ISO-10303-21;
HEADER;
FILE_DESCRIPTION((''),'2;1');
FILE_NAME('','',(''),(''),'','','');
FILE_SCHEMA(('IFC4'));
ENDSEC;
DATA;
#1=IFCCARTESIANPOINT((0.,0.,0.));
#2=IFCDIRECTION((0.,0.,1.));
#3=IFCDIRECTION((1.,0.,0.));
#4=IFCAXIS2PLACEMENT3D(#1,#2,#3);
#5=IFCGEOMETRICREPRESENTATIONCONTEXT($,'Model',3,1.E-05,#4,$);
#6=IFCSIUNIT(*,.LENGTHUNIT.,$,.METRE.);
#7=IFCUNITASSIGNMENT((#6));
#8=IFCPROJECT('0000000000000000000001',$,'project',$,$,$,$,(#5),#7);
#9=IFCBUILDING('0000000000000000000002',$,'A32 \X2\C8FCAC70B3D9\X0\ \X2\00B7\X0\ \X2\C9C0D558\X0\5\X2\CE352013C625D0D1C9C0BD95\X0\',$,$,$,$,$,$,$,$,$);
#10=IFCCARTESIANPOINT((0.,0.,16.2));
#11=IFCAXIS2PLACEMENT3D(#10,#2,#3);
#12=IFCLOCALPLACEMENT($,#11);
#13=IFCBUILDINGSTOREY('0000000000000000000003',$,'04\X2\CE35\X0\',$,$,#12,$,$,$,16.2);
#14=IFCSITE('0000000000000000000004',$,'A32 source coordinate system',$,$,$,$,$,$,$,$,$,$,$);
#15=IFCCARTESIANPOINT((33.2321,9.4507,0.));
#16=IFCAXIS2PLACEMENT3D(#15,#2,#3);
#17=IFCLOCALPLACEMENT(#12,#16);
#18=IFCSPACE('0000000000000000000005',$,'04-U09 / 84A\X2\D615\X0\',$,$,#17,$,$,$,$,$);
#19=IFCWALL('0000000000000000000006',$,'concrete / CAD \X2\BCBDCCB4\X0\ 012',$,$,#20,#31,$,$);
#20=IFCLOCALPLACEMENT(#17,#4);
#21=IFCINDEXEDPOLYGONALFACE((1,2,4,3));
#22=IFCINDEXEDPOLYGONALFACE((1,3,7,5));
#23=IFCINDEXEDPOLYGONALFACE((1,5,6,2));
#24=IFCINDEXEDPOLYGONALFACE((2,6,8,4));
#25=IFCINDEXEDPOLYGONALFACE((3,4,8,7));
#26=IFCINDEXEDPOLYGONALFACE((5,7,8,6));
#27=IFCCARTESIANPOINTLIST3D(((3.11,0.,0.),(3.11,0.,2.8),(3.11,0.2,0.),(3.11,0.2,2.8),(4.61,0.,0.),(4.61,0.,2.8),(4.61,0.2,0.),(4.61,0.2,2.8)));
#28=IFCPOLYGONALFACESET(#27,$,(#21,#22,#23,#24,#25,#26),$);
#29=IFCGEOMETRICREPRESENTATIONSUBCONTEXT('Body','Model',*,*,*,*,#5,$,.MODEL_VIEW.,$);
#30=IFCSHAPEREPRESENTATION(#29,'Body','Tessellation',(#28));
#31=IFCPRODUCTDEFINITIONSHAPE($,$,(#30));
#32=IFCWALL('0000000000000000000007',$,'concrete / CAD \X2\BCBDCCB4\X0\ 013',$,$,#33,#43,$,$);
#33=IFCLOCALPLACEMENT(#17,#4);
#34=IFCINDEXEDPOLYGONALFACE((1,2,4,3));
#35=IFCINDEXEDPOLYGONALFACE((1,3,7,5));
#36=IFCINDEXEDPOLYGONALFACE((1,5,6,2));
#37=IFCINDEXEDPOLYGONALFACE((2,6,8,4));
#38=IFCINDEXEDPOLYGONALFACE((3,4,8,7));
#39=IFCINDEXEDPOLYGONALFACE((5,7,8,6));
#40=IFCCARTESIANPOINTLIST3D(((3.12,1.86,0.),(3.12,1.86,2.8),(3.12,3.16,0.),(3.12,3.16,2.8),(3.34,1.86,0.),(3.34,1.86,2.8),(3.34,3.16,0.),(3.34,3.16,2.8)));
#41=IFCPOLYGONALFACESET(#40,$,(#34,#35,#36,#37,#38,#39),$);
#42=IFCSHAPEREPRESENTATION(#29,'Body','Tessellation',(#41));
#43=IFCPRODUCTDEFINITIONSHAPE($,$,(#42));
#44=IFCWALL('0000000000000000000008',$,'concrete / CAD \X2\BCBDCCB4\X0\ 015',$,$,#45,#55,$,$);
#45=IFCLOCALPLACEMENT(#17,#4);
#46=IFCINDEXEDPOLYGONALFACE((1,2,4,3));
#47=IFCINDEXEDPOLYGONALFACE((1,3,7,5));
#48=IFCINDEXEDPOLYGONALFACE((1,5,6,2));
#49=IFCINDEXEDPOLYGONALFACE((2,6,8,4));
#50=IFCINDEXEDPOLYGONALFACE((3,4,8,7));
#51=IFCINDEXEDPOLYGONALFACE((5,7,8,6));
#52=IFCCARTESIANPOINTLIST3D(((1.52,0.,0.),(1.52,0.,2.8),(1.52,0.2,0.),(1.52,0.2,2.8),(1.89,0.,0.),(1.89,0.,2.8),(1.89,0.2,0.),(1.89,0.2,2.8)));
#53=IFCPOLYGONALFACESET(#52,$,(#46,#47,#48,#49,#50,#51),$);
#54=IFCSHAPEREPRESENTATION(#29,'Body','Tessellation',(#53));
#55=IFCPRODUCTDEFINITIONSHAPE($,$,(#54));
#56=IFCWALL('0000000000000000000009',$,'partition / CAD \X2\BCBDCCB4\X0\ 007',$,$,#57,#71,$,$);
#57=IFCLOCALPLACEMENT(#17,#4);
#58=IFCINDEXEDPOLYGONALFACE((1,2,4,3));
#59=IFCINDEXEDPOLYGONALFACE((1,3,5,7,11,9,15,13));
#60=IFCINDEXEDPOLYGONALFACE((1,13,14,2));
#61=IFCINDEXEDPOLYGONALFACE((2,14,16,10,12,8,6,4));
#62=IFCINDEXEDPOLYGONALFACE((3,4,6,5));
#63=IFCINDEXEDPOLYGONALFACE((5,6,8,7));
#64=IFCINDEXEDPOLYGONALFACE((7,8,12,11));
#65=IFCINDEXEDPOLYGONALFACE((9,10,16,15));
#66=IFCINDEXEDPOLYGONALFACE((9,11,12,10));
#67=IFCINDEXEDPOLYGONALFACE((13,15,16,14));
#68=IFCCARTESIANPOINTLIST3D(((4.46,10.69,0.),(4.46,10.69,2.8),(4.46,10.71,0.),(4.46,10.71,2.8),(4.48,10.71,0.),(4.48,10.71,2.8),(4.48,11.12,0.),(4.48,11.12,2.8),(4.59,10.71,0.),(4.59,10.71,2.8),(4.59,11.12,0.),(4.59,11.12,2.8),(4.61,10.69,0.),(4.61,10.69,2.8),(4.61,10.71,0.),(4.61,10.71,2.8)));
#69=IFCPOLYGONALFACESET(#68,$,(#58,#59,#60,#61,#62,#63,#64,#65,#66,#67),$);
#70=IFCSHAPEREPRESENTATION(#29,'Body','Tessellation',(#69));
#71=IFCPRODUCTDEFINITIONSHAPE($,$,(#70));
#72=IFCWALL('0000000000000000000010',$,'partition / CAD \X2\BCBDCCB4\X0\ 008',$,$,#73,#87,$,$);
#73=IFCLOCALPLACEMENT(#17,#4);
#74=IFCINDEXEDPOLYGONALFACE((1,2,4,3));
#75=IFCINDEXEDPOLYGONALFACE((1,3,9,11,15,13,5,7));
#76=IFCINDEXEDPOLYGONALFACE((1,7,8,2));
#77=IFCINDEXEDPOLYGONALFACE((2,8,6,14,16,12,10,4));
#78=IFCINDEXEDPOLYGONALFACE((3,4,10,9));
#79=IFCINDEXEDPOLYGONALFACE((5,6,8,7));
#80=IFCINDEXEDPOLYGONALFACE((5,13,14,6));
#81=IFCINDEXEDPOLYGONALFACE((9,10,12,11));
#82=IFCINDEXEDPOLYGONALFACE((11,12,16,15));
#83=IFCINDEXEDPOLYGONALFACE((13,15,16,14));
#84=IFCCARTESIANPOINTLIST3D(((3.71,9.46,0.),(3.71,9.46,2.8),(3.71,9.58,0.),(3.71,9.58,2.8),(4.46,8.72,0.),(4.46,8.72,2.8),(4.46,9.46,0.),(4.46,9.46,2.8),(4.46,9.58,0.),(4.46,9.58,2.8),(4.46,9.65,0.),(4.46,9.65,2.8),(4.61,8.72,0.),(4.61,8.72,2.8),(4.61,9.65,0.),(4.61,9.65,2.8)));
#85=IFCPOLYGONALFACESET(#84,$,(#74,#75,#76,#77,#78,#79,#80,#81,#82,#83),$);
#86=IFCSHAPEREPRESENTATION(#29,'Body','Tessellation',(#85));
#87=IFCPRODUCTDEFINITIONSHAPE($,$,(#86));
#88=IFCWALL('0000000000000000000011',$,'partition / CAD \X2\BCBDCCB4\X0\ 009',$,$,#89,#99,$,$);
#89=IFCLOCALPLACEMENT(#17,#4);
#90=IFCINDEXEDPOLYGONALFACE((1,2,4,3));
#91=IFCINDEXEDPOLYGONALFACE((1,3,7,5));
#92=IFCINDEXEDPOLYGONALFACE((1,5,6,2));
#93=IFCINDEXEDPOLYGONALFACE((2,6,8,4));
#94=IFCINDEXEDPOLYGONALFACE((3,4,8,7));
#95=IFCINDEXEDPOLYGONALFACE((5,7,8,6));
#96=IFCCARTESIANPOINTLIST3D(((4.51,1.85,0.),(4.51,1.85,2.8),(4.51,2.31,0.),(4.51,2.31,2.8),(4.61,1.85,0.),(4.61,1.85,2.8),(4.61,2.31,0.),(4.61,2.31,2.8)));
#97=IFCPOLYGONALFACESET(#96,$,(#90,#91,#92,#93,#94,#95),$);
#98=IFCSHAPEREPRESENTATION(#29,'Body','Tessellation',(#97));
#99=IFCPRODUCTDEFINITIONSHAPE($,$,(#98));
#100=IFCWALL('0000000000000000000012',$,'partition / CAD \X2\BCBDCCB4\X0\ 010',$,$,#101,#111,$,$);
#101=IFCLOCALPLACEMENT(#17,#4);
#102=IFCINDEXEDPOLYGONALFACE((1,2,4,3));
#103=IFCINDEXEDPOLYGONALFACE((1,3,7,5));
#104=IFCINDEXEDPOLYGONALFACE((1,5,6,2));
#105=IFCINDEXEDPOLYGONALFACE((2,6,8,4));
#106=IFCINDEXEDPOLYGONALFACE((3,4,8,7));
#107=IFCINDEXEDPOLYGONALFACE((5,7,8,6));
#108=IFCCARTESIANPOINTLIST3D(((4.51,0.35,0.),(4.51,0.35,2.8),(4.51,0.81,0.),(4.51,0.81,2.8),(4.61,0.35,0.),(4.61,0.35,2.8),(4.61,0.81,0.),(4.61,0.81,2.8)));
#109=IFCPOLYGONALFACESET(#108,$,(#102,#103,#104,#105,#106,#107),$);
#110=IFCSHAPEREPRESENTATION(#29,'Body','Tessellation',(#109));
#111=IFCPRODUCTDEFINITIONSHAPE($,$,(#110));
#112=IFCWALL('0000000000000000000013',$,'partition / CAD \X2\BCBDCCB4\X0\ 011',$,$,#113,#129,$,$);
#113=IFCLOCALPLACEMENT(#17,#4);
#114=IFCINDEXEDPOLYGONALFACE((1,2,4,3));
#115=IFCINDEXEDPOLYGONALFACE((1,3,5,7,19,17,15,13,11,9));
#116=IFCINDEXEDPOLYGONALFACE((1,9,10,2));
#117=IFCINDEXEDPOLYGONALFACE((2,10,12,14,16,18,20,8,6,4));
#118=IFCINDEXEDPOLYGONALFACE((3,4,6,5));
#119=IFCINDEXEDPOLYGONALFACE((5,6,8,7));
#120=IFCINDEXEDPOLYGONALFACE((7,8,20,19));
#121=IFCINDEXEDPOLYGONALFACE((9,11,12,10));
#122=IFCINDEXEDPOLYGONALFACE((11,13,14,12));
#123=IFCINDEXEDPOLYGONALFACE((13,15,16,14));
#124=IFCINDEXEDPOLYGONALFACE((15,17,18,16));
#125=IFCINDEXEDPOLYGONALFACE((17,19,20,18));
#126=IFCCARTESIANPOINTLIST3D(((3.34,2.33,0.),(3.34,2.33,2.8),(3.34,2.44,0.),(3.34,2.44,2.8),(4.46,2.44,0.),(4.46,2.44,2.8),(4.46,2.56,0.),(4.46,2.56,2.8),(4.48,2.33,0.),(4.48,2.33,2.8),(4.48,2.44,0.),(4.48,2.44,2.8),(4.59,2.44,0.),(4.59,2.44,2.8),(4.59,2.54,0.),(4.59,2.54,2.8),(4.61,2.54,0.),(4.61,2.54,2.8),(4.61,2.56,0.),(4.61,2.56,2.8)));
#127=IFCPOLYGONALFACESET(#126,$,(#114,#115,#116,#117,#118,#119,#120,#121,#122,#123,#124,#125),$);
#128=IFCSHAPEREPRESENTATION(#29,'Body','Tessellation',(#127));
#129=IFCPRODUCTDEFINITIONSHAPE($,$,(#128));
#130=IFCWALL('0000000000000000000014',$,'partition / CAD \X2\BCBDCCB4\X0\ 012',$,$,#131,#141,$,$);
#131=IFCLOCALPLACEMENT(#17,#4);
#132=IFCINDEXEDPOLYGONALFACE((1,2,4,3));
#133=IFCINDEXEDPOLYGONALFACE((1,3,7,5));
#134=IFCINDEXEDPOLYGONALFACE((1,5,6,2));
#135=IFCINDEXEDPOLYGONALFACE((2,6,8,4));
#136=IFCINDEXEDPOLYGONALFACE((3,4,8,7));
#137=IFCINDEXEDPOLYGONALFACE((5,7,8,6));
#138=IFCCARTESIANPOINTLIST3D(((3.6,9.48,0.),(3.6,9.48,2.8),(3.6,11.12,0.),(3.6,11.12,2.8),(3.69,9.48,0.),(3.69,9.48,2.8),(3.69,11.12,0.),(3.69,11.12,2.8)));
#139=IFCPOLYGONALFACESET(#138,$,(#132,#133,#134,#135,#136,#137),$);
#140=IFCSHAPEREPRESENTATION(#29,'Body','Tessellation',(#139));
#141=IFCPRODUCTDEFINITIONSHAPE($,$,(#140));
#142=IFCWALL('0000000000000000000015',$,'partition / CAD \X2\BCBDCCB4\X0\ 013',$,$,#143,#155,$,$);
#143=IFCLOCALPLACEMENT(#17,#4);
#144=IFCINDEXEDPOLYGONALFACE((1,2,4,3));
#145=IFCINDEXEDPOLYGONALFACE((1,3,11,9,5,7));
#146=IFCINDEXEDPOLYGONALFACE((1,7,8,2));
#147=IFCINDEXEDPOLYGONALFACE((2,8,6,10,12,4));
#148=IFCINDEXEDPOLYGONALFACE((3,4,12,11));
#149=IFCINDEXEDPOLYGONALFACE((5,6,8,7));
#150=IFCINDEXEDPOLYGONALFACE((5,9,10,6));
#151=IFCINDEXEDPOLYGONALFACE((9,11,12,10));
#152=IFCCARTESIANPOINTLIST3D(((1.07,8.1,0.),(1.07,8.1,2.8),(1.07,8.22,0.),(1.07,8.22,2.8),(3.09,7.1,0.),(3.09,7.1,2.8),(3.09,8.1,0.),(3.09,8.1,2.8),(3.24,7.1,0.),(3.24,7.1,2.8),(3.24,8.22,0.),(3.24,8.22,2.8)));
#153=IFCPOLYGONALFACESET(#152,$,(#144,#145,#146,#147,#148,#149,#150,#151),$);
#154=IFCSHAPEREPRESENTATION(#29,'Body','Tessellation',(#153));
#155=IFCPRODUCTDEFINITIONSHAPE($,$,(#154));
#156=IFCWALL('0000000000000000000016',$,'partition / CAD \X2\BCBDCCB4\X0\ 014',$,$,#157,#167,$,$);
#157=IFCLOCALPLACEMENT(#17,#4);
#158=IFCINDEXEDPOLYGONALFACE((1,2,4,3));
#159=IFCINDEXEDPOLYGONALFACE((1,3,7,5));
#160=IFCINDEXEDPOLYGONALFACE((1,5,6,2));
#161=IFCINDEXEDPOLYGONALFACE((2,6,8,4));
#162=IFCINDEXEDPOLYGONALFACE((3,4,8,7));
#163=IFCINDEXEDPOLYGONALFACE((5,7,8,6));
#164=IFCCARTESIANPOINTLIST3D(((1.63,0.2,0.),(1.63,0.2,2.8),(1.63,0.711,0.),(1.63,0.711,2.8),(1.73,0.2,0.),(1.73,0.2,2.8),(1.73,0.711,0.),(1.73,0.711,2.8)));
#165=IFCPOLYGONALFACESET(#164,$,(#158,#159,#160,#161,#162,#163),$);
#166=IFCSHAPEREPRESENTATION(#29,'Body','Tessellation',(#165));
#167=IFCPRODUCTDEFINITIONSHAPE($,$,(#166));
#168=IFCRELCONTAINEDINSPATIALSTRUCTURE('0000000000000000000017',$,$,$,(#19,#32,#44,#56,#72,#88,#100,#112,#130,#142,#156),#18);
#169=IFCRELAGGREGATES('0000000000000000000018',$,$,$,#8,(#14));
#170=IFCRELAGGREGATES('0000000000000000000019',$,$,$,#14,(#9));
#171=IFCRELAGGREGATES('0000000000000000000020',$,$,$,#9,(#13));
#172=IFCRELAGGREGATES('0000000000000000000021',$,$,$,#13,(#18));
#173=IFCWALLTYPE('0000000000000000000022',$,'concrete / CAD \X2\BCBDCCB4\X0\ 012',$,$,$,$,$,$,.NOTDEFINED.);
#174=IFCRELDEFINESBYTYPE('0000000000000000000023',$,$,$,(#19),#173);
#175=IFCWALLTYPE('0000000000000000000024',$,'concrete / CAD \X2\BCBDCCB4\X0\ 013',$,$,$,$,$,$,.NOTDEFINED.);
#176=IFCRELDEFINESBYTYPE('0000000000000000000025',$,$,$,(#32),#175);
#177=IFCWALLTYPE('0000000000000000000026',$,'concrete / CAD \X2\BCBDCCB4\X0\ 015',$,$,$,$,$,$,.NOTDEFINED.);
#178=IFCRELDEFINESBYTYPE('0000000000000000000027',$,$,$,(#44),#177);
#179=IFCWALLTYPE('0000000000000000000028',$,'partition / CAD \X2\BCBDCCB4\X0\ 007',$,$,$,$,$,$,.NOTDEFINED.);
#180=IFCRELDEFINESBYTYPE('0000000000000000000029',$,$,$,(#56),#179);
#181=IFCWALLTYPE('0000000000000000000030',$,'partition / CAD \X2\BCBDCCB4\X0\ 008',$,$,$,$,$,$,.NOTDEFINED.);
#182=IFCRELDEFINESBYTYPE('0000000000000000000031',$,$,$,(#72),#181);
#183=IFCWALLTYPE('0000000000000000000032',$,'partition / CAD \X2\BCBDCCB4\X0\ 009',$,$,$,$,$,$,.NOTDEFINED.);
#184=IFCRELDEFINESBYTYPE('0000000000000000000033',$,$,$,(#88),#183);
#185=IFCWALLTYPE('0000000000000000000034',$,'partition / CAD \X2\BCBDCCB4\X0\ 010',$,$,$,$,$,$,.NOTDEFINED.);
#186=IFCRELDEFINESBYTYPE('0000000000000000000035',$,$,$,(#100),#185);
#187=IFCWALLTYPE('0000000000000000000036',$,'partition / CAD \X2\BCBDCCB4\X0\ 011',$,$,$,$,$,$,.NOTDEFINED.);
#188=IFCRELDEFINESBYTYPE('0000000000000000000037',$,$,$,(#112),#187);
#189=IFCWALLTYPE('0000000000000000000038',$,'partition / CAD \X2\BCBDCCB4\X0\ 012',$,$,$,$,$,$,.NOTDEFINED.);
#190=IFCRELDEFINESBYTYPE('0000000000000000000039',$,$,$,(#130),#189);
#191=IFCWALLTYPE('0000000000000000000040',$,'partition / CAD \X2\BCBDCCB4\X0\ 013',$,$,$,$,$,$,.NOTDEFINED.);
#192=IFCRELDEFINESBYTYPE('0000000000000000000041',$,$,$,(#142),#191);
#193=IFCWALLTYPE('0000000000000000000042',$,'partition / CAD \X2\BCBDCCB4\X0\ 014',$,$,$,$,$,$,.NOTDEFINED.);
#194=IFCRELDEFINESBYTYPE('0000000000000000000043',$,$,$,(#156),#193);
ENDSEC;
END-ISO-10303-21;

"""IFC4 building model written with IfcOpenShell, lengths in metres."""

from ifc_helpers import new_model, si_unit, frame, origin, origin_with_axes, place, context, subcontext, project, spatial, polyline, outline, extrude, source, transform, mapped, type_object, type_shapes, element, save


model = new_model("IFC4")

# Units and contexts
model_context = context("Model", 3, precision=1e-05, world=origin_with_axes())
body_context = subcontext(model_context, "Body", "Model", "MODEL_VIEW")
ifc_project = project(units=[si_unit("LENGTHUNIT", "METRE")], contexts=[model_context])

# Site, building, storey, space
storey_placement = place(None, frame((0.0, 0.0, 16.2), z_axis=(0.0, 0.0, 1.0), x_axis=(1.0, 0.0, 0.0)))
space_placement = place(storey_placement, frame((33.2321, 9.4507, 0.0), z_axis=(0.0, 0.0, 1.0), x_axis=(1.0, 0.0, 0.0)))
site = spatial("IfcSite", under=ifc_project, Name="A32 source coordinate system")
building = spatial("IfcBuilding", under=site, Name="A32 주거동 · 지하5층–옥탑지붕")
storey = spatial("IfcBuildingStorey", under=building, at=storey_placement, Name="04층", Elevation=16.2)
space = spatial("IfcSpace", under=storey, at=space_placement, Name="04-U09 / 84A형")

# Walls
wall_type_1 = type_object("IfcWallType", Name="concrete / CAD 벽체 012", PredefinedType="NOTDEFINED")
shared_shape_1 = source(origin(), body_context, "Body", "SweptSolid", [
    extrude(outline(polyline([(3.11, 0.0), (3.11, 0.2), (4.61, 0.2), (4.61, 0.0), (3.11, 0.0)])), origin(), (0.0, 0.0, 1.0), 2.8),
])
type_shapes(wall_type_1, [shared_shape_1])
wall_1_placement = place(space_placement, origin_with_axes())
element("IfcWall", 1, at=wall_1_placement, inside=space, type_object=wall_type_1, Name="concrete / CAD 벽체 012", context=body_context, shape_type="MappedRepresentation", body=[
    mapped(shared_shape_1, transform((0.0, 0.0, 0.0), scale=1.0)),
])
wall_type_2 = type_object("IfcWallType", Name="concrete / CAD 벽체 013", PredefinedType="NOTDEFINED")
shared_shape_2 = source(origin(), body_context, "Body", "SweptSolid", [
    extrude(outline(polyline([(3.12, 3.16), (3.34, 3.16), (3.34, 1.86), (3.12, 1.86), (3.12, 3.16)])), origin(), (0.0, 0.0, 1.0), 2.8),
])
type_shapes(wall_type_2, [shared_shape_2])
wall_2_placement = place(space_placement, origin_with_axes())
element("IfcWall", 2, at=wall_2_placement, inside=space, type_object=wall_type_2, Name="concrete / CAD 벽체 013", context=body_context, shape_type="MappedRepresentation", body=[
    mapped(shared_shape_2, transform((0.0, 0.0, 0.0), scale=1.0)),
])
wall_type_3 = type_object("IfcWallType", Name="concrete / CAD 벽체 015", PredefinedType="NOTDEFINED")
shared_shape_3 = source(origin(), body_context, "Body", "SweptSolid", [
    extrude(outline(polyline([(1.52, 0.2), (1.89, 0.2), (1.89, 0.0), (1.52, 0.0), (1.52, 0.2)])), origin(), (0.0, 0.0, 1.0), 2.8),
])
type_shapes(wall_type_3, [shared_shape_3])
wall_3_placement = place(space_placement, origin_with_axes())
element("IfcWall", 3, at=wall_3_placement, inside=space, type_object=wall_type_3, Name="concrete / CAD 벽체 015", context=body_context, shape_type="MappedRepresentation", body=[
    mapped(shared_shape_3, transform((0.0, 0.0, 0.0), scale=1.0)),
])
wall_type_4 = type_object("IfcWallType", Name="partition / CAD 벽체 007", PredefinedType="NOTDEFINED")
shared_shape_4 = source(origin(), body_context, "Body", "SweptSolid", [
    extrude(outline(polyline([(4.46, 10.71), (4.48, 10.71), (4.48, 11.12), (4.59, 11.12), (4.59, 10.71), (4.61, 10.71), (4.61, 10.69), (4.46, 10.69), (4.46, 10.71)])), origin(), (0.0, 0.0, 1.0), 2.8),
])
type_shapes(wall_type_4, [shared_shape_4])
wall_4_placement = place(space_placement, origin_with_axes())
element("IfcWall", 4, at=wall_4_placement, inside=space, type_object=wall_type_4, Name="partition / CAD 벽체 007", context=body_context, shape_type="MappedRepresentation", body=[
    mapped(shared_shape_4, transform((0.0, 0.0, 0.0), scale=1.0)),
])
wall_type_5 = type_object("IfcWallType", Name="partition / CAD 벽체 008", PredefinedType="NOTDEFINED")
shared_shape_5 = source(origin(), body_context, "Body", "SweptSolid", [
    extrude(outline(polyline([(4.61, 8.72), (4.46, 8.72), (4.46, 9.46), (3.71, 9.46), (3.71, 9.58), (4.46, 9.58), (4.46, 9.65), (4.61, 9.65), (4.61, 8.72)])), origin(), (0.0, 0.0, 1.0), 2.8),
])
type_shapes(wall_type_5, [shared_shape_5])
wall_5_placement = place(space_placement, origin_with_axes())
element("IfcWall", 5, at=wall_5_placement, inside=space, type_object=wall_type_5, Name="partition / CAD 벽체 008", context=body_context, shape_type="MappedRepresentation", body=[
    mapped(shared_shape_5, transform((0.0, 0.0, 0.0), scale=1.0)),
])
wall_type_6 = type_object("IfcWallType", Name="partition / CAD 벽체 009", PredefinedType="NOTDEFINED")
shared_shape_6 = source(origin(), body_context, "Body", "SweptSolid", [
    extrude(outline(polyline([(4.51, 1.85), (4.51, 2.31), (4.61, 2.31), (4.61, 1.85), (4.51, 1.85)])), origin(), (0.0, 0.0, 1.0), 2.8),
])
type_shapes(wall_type_6, [shared_shape_6])
wall_6_placement = place(space_placement, origin_with_axes())
element("IfcWall", 6, at=wall_6_placement, inside=space, type_object=wall_type_6, Name="partition / CAD 벽체 009", context=body_context, shape_type="MappedRepresentation", body=[
    mapped(shared_shape_6, transform((0.0, 0.0, 0.0), scale=1.0)),
])
wall_type_7 = type_object("IfcWallType", Name="partition / CAD 벽체 010", PredefinedType="NOTDEFINED")
shared_shape_7 = source(origin(), body_context, "Body", "SweptSolid", [
    extrude(outline(polyline([(4.51, 0.81), (4.61, 0.81), (4.61, 0.35), (4.51, 0.35), (4.51, 0.81)])), origin(), (0.0, 0.0, 1.0), 2.8),
])
type_shapes(wall_type_7, [shared_shape_7])
wall_7_placement = place(space_placement, origin_with_axes())
element("IfcWall", 7, at=wall_7_placement, inside=space, type_object=wall_type_7, Name="partition / CAD 벽체 010", context=body_context, shape_type="MappedRepresentation", body=[
    mapped(shared_shape_7, transform((0.0, 0.0, 0.0), scale=1.0)),
])
wall_type_8 = type_object("IfcWallType", Name="partition / CAD 벽체 011", PredefinedType="NOTDEFINED")
shared_shape_8 = source(origin(), body_context, "Body", "SweptSolid", [
    extrude(outline(polyline([(3.34, 2.33), (3.34, 2.44), (4.46, 2.44), (4.46, 2.56), (4.61, 2.56), (4.61, 2.54), (4.59, 2.54), (4.59, 2.44), (4.48, 2.44), (4.48, 2.33), (3.34, 2.33)])), origin(), (0.0, 0.0, 1.0), 2.8),
])
type_shapes(wall_type_8, [shared_shape_8])
wall_8_placement = place(space_placement, origin_with_axes())
element("IfcWall", 8, at=wall_8_placement, inside=space, type_object=wall_type_8, Name="partition / CAD 벽체 011", context=body_context, shape_type="MappedRepresentation", body=[
    mapped(shared_shape_8, transform((0.0, 0.0, 0.0), scale=1.0)),
])
wall_type_9 = type_object("IfcWallType", Name="partition / CAD 벽체 012", PredefinedType="NOTDEFINED")
shared_shape_9 = source(origin(), body_context, "Body", "SweptSolid", [
    extrude(outline(polyline([(3.6, 11.12), (3.69, 11.12), (3.69, 9.48), (3.6, 9.48), (3.6, 11.12)])), origin(), (0.0, 0.0, 1.0), 2.8),
])
type_shapes(wall_type_9, [shared_shape_9])
wall_9_placement = place(space_placement, origin_with_axes())
element("IfcWall", 9, at=wall_9_placement, inside=space, type_object=wall_type_9, Name="partition / CAD 벽체 012", context=body_context, shape_type="MappedRepresentation", body=[
    mapped(shared_shape_9, transform((0.0, 0.0, 0.0), scale=1.0)),
])
wall_type_10 = type_object("IfcWallType", Name="partition / CAD 벽체 013", PredefinedType="NOTDEFINED")
shared_shape_10 = source(origin(), body_context, "Body", "SweptSolid", [
    extrude(outline(polyline([(3.09, 8.1), (1.07, 8.1), (1.07, 8.22), (3.24, 8.22), (3.24, 7.1), (3.09, 7.1), (3.09, 8.1)])), origin(), (0.0, 0.0, 1.0), 2.8),
])
type_shapes(wall_type_10, [shared_shape_10])
wall_10_placement = place(space_placement, origin_with_axes())
element("IfcWall", 10, at=wall_10_placement, inside=space, type_object=wall_type_10, Name="partition / CAD 벽체 013", context=body_context, shape_type="MappedRepresentation", body=[
    mapped(shared_shape_10, transform((0.0, 0.0, 0.0), scale=1.0)),
])
wall_type_11 = type_object("IfcWallType", Name="partition / CAD 벽체 014", PredefinedType="NOTDEFINED")
shared_shape_11 = source(origin(), body_context, "Body", "SweptSolid", [
    extrude(outline(polyline([(1.73, 0.2), (1.63, 0.2), (1.63, 0.711), (1.73, 0.711), (1.73, 0.2)])), origin(), (0.0, 0.0, 1.0), 2.8),
])
type_shapes(wall_type_11, [shared_shape_11])
wall_11_placement = place(space_placement, origin_with_axes())
element("IfcWall", 11, at=wall_11_placement, inside=space, type_object=wall_type_11, Name="partition / CAD 벽체 014", context=body_context, shape_type="MappedRepresentation", body=[
    mapped(shared_shape_11, transform((0.0, 0.0, 0.0), scale=1.0)),
])

save(model, "model.ifc")
